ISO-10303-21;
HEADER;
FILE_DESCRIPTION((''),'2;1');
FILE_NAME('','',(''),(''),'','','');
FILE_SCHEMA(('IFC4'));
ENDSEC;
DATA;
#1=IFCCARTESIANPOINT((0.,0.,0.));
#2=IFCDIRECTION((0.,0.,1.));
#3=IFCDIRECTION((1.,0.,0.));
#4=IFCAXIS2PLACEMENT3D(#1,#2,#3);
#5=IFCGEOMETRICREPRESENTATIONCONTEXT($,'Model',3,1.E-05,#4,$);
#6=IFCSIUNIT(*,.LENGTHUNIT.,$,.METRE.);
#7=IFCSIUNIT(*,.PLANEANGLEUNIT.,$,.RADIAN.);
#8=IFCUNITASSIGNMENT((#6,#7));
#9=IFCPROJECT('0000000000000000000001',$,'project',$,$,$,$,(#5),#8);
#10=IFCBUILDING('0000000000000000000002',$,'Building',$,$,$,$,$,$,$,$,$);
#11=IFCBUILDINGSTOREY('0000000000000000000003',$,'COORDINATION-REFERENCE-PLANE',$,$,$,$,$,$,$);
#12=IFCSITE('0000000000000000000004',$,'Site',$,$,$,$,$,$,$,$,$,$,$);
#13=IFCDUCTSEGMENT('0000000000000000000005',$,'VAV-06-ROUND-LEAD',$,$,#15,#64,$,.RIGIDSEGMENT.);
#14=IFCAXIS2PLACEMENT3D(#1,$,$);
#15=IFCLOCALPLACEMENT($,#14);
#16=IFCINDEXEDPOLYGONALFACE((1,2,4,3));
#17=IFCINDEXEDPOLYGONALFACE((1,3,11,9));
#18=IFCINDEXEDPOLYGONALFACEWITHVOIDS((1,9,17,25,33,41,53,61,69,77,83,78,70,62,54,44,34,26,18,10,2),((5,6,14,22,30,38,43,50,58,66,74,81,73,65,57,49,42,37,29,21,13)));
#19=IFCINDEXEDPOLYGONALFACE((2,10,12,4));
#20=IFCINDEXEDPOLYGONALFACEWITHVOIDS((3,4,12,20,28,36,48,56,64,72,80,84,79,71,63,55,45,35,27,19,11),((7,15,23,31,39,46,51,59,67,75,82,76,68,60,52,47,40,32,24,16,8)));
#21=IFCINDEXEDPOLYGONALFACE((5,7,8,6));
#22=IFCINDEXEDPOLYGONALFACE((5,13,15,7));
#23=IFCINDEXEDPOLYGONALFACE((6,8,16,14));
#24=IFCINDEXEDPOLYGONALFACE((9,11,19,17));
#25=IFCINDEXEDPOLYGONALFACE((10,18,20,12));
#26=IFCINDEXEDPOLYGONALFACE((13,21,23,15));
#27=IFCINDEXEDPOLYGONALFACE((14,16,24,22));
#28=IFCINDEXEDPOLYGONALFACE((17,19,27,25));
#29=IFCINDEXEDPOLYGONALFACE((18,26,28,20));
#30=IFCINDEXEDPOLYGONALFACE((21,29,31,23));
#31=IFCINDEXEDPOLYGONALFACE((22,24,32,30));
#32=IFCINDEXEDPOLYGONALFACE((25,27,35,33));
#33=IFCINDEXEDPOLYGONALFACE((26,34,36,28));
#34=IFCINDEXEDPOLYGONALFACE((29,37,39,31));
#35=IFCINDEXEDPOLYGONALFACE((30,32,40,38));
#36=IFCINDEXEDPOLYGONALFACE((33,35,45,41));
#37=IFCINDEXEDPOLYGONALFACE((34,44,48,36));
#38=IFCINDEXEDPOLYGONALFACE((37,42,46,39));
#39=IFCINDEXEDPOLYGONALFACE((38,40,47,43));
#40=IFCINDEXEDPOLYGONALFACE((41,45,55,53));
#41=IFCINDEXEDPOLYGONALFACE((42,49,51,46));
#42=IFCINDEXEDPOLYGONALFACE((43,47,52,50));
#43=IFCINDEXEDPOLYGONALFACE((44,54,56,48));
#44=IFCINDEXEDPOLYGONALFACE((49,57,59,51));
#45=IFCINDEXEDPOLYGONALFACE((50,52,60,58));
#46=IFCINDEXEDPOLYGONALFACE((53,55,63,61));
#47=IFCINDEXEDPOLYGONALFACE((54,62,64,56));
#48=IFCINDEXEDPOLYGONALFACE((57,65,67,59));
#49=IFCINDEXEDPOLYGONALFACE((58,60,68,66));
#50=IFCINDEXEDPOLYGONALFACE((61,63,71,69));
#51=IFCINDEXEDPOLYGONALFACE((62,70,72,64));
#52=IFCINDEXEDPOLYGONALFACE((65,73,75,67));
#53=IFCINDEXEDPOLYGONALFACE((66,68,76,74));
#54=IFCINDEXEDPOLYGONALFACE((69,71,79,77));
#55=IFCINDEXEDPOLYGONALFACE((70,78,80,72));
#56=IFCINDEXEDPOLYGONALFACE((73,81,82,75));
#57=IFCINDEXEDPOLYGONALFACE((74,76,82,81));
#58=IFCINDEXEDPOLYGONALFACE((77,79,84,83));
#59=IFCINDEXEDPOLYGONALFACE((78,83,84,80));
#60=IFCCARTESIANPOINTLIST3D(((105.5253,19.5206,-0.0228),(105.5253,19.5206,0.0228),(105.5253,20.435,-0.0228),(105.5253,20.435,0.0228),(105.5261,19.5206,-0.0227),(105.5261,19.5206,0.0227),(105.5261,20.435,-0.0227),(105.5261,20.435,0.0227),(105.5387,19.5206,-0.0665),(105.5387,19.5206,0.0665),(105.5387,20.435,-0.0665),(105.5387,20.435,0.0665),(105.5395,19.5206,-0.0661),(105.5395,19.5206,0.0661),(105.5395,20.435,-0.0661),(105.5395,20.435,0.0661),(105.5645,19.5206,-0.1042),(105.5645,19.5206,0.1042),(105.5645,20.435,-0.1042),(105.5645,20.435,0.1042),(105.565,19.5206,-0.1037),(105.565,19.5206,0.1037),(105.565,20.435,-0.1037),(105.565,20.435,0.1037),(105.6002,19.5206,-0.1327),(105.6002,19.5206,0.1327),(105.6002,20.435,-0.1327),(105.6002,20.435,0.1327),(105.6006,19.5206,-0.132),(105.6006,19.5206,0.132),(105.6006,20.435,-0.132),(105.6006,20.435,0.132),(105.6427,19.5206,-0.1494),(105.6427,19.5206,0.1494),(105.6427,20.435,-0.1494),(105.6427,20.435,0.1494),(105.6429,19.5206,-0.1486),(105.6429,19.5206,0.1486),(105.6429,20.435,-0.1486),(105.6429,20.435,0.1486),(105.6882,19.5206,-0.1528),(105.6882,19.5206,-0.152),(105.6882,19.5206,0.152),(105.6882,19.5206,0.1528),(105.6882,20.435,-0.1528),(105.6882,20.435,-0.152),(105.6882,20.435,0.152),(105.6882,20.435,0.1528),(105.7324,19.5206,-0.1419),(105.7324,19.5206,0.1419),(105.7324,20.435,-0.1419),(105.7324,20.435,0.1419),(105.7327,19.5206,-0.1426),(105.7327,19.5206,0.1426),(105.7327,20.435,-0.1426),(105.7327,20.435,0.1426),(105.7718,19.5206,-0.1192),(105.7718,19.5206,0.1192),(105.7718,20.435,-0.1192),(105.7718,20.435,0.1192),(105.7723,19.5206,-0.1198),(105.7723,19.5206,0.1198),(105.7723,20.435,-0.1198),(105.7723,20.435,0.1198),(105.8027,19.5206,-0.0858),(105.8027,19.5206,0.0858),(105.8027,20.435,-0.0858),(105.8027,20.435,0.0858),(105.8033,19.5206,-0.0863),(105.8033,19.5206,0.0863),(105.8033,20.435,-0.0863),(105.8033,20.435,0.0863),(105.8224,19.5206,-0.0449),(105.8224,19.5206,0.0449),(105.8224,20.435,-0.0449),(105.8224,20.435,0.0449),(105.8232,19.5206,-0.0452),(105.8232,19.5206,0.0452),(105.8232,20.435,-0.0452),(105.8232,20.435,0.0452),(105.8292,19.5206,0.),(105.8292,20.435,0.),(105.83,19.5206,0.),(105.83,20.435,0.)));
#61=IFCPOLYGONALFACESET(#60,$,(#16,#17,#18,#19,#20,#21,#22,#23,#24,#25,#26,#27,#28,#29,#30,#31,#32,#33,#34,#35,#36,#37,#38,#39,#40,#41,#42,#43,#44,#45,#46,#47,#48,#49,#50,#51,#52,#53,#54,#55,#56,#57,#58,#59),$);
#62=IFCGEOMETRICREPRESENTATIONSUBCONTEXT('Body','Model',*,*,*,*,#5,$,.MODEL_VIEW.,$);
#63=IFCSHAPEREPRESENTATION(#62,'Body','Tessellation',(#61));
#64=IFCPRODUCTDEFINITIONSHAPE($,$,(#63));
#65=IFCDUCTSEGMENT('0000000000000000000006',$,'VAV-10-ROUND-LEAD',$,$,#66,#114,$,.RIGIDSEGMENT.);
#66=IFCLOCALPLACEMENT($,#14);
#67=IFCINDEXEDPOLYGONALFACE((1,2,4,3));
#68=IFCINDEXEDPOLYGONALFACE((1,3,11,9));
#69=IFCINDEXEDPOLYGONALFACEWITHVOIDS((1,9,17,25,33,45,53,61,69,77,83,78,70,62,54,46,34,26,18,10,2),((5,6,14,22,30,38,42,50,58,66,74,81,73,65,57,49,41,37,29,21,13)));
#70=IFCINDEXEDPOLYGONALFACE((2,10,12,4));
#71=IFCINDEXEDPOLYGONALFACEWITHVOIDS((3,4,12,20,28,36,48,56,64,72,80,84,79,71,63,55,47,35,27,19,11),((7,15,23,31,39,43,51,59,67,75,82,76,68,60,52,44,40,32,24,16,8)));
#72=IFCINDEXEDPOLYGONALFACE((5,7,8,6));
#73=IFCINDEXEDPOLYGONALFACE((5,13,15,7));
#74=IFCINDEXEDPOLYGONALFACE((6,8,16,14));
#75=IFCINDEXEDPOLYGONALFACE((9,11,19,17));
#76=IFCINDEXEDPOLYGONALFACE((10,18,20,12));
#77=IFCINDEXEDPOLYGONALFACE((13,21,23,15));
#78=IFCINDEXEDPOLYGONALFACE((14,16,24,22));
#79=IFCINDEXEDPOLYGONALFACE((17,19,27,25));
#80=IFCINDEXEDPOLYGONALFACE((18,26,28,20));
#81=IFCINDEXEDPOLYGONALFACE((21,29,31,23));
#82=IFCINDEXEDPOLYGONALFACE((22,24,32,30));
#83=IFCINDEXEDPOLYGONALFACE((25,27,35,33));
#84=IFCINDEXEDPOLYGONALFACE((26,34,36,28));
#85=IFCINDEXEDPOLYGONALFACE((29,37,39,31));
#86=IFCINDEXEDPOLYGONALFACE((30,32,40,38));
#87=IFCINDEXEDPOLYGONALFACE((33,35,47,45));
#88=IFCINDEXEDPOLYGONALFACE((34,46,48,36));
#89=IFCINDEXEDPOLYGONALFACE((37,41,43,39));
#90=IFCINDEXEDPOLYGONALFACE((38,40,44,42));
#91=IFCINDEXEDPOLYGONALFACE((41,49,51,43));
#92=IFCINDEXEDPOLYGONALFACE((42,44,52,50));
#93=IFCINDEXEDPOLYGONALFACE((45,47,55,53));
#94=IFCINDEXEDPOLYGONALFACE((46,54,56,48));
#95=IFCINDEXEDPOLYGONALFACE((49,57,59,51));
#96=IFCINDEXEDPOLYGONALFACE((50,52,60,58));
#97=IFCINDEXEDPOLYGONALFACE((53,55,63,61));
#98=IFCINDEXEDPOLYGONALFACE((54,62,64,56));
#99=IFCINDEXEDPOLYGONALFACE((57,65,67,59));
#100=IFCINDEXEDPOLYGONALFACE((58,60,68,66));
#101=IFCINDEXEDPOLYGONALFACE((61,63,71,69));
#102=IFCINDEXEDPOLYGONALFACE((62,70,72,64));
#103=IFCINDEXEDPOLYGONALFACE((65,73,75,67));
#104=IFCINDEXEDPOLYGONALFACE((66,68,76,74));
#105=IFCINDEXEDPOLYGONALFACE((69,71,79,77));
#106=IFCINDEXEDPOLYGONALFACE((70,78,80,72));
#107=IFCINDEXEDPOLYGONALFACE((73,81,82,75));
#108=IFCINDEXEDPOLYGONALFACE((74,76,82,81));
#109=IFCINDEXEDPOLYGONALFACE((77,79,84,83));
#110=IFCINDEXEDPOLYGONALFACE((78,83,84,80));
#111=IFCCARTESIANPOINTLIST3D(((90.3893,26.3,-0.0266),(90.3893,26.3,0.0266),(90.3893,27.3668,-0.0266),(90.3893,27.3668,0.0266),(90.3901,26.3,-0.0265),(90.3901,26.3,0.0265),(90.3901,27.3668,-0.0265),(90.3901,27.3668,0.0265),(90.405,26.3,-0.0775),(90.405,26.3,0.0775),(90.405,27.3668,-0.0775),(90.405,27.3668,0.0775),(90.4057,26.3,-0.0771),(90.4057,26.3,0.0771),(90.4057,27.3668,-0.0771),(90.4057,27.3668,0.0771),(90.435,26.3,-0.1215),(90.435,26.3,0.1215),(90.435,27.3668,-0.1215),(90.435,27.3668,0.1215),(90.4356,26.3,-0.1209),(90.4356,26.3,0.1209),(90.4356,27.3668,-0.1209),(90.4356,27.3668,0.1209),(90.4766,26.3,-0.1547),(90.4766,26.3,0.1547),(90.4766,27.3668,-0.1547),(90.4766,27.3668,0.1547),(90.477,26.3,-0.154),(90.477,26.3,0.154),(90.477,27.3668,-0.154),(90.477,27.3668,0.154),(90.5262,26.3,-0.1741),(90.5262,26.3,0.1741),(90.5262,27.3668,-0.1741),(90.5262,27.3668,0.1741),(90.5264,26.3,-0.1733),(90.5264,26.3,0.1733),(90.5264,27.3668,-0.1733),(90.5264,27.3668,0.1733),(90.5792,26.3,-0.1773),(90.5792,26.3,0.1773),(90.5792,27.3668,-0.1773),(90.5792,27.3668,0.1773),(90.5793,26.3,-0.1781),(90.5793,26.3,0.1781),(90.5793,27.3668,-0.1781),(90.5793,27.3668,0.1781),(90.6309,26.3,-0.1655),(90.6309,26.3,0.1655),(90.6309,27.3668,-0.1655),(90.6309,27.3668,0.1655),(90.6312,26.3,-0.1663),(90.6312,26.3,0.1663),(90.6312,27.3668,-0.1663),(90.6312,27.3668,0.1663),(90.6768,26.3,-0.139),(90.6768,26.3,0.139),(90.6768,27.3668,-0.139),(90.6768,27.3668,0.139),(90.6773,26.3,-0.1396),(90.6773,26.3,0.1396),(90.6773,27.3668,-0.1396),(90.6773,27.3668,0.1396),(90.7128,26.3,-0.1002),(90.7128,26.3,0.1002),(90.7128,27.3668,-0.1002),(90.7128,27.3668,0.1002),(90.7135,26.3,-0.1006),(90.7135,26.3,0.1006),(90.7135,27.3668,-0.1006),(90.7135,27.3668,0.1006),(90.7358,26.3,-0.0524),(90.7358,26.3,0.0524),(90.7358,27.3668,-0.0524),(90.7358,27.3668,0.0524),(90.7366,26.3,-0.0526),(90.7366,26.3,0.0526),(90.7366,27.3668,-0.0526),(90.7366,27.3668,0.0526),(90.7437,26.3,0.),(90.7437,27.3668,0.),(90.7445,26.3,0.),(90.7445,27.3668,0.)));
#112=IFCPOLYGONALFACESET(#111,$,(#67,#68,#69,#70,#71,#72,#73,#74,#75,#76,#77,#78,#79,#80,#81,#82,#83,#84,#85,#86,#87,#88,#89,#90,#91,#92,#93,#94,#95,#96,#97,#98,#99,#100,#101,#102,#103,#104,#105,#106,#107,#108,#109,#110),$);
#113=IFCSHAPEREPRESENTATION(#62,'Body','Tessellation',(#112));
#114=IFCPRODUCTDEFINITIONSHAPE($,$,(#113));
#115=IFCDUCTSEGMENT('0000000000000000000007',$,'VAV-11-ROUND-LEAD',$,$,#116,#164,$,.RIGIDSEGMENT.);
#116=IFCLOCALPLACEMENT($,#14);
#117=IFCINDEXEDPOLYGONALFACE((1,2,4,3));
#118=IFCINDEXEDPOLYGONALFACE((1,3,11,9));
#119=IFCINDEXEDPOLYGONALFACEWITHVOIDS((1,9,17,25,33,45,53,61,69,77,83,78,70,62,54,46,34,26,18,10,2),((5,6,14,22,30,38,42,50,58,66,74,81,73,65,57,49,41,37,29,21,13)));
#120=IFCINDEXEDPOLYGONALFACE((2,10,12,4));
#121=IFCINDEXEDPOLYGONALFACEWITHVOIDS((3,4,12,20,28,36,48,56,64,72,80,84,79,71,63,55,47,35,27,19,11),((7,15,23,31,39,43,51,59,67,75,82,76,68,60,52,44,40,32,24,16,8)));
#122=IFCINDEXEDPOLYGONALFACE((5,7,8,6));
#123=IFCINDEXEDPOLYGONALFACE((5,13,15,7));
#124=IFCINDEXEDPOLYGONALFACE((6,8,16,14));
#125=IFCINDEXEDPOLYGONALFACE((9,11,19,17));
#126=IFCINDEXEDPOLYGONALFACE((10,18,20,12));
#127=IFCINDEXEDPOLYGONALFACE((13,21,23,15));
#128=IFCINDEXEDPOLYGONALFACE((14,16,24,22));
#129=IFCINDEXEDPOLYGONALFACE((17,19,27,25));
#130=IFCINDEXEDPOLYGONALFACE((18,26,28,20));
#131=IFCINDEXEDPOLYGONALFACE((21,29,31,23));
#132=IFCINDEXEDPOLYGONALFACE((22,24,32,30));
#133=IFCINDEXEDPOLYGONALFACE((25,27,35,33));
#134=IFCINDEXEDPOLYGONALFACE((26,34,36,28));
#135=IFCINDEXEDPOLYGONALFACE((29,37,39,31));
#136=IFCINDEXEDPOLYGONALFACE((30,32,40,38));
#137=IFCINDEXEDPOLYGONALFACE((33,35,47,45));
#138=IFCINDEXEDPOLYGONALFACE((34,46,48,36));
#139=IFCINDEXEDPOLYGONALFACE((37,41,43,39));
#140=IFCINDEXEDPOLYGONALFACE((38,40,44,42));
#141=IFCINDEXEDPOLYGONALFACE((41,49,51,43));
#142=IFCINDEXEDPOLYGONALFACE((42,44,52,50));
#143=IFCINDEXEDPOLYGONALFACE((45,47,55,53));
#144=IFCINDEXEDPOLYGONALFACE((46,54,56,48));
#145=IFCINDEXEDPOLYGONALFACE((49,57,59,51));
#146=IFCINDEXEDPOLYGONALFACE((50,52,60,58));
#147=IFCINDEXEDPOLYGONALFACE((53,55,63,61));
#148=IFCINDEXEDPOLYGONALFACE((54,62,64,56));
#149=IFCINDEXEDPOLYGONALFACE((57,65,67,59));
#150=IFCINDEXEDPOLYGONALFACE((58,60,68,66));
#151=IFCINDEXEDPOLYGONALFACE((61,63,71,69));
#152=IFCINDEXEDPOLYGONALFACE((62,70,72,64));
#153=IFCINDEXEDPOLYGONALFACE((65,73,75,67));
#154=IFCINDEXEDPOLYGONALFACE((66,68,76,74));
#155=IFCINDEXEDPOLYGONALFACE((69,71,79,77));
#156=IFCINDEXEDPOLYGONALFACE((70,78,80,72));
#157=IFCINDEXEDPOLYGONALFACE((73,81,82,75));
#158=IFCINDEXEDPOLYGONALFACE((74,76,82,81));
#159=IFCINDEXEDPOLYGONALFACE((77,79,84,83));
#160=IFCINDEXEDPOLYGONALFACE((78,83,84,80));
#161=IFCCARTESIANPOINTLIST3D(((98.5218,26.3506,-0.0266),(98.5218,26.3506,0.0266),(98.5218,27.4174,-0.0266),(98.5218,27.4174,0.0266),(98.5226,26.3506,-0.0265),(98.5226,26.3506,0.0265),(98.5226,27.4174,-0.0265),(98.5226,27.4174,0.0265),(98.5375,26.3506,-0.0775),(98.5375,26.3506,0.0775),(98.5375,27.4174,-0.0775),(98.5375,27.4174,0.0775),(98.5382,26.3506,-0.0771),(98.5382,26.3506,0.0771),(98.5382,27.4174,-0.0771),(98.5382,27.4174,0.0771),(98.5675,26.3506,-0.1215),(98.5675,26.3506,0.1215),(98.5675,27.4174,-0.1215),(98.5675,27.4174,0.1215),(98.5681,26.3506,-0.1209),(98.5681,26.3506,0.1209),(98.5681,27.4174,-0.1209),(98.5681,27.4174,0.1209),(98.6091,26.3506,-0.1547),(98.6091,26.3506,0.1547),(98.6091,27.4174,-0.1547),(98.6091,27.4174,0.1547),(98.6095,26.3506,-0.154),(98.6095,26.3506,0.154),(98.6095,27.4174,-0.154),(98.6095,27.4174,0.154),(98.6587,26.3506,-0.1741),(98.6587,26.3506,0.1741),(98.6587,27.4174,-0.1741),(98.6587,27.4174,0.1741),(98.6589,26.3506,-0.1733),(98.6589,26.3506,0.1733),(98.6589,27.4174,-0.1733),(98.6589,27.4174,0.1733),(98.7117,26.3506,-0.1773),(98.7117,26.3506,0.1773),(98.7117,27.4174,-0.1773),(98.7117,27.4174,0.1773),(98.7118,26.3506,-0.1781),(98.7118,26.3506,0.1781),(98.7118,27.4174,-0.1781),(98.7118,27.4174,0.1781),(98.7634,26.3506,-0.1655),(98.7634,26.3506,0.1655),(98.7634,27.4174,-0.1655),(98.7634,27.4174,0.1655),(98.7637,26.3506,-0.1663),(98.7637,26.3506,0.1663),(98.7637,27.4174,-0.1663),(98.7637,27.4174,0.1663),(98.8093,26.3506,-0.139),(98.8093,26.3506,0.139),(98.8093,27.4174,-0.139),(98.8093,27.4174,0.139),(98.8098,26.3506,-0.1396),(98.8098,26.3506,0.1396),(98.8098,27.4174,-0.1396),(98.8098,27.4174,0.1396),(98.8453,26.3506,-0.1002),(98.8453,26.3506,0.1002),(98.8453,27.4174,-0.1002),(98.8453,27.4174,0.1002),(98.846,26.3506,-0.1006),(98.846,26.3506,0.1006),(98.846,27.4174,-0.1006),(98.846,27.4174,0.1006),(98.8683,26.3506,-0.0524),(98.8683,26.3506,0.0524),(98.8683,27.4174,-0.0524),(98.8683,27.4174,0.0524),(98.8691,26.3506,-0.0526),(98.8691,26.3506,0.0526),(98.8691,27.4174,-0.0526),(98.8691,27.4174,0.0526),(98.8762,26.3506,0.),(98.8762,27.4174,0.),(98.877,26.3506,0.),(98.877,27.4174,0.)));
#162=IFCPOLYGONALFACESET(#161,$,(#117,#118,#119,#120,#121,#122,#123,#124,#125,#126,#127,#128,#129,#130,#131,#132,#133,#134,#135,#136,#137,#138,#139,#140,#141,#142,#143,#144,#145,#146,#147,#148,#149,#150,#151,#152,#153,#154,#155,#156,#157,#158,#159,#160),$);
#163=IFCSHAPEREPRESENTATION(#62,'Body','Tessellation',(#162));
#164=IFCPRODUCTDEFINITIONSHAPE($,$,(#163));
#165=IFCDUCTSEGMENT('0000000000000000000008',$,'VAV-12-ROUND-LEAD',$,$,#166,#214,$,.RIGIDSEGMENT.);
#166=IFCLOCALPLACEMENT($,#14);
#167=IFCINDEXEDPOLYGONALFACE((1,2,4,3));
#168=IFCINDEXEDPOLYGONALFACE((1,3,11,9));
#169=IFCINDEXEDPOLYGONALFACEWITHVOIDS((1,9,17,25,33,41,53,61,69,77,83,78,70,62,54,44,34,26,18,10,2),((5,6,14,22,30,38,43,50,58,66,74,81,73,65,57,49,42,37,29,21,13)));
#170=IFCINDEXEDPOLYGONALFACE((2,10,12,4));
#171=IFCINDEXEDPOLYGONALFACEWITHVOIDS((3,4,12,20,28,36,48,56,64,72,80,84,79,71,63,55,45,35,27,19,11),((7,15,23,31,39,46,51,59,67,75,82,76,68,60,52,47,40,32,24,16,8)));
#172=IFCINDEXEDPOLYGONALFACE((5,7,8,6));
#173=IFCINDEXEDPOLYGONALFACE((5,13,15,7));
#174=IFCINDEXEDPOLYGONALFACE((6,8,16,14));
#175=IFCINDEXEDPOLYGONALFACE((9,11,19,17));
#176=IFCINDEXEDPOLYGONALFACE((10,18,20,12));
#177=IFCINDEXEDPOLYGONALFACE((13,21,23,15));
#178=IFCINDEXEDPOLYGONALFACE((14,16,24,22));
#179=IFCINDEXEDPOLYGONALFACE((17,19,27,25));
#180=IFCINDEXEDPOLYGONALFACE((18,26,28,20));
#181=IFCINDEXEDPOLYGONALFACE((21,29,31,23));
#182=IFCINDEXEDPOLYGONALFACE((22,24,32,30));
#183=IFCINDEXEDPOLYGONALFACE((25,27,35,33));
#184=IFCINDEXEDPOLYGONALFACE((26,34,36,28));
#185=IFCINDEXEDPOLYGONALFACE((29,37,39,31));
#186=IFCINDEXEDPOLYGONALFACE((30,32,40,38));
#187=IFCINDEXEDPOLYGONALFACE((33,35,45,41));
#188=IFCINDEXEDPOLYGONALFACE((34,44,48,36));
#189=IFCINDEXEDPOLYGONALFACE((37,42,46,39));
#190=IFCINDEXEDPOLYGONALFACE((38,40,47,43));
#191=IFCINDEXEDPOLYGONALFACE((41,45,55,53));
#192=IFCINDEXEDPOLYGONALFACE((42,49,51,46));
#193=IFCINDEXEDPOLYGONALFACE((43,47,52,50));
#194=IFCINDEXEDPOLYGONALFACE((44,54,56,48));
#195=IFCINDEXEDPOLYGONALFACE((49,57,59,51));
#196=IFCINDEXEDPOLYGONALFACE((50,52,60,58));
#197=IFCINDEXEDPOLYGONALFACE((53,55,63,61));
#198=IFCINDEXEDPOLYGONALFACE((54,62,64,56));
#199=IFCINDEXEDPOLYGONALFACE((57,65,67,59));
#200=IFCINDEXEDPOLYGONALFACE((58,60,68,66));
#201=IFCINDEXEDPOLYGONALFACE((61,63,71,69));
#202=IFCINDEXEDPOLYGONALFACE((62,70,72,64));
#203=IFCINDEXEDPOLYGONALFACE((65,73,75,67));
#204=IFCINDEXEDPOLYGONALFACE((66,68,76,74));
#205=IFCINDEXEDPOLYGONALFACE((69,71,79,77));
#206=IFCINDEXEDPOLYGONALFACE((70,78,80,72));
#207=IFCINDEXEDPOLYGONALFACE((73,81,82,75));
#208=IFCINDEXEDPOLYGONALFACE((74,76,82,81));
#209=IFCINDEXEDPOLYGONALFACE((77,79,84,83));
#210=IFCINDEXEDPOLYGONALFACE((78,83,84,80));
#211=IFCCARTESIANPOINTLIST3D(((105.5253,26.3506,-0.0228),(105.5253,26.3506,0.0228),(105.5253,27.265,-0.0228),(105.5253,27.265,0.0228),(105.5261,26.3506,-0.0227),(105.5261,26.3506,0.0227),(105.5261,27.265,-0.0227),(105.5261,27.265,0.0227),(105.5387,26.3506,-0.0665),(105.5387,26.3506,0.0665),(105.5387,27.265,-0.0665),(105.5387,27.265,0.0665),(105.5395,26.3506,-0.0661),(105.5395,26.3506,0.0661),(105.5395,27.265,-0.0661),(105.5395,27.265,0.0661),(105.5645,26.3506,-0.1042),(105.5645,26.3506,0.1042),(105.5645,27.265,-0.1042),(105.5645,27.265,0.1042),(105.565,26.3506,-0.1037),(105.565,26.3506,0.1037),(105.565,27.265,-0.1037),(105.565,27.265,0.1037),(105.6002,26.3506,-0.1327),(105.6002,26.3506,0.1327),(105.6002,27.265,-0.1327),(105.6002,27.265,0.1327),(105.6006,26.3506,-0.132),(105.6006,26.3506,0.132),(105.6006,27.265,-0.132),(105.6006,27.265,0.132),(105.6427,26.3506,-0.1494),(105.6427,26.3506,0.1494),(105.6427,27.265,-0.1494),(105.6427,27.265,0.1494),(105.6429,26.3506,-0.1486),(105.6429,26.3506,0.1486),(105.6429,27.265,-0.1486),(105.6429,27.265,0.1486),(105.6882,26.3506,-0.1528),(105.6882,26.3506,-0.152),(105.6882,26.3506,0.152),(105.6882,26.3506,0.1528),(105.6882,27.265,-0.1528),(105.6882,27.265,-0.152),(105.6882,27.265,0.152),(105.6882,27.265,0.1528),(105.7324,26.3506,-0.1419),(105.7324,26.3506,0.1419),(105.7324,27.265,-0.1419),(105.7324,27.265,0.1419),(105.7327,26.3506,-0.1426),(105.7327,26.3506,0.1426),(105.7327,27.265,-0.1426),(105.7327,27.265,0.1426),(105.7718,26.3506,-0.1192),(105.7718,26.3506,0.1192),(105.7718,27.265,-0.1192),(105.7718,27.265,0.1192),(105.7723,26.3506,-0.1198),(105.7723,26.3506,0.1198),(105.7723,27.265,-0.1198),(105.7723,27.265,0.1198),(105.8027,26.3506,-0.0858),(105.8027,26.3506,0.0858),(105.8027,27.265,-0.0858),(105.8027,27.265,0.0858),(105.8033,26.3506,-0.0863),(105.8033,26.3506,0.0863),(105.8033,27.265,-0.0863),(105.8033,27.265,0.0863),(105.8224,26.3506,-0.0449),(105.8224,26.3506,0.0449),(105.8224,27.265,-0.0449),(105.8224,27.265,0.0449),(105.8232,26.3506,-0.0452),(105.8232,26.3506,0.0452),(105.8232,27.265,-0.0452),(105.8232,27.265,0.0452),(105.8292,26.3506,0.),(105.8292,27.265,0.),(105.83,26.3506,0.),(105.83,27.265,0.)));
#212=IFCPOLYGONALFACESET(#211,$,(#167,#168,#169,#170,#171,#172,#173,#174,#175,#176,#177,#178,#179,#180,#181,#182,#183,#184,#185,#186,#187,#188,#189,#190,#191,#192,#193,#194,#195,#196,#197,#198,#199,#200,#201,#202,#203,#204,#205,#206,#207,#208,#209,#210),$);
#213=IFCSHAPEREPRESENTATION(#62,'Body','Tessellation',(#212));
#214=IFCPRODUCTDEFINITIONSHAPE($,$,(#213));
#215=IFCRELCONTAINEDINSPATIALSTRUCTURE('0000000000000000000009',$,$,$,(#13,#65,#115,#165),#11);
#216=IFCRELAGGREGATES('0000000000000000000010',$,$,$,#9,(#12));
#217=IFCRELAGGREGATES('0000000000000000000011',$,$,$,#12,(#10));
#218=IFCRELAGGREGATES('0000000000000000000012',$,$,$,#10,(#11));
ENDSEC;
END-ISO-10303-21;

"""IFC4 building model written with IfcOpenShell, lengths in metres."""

from ifc_helpers import new_model, si_unit, frame, origin, origin_with_axes, place, context, subcontext, project, spatial, hollow_circle, extrude, element, save


model = new_model("IFC4")

# Units and contexts
model_context = context("Model", 3, precision=1e-05, world=origin_with_axes())
body_context_1 = subcontext(model_context, "Body", "Model", "MODEL_VIEW")
ifc_project = project(units=[si_unit("LENGTHUNIT", "METRE"), si_unit("PLANEANGLEUNIT", "RADIAN")], contexts=[model_context])

# Site, building, storey
site = spatial("IfcSite", under=ifc_project, Name="Site")
building = spatial("IfcBuilding", under=site, Name="Building")
storey = spatial("IfcBuildingStorey", under=building, Name="COORDINATION-REFERENCE-PLANE")

# Duct segments
duct_segment_1_placement = place(None, frame((105.6768, 20.435, 0.0), z_axis=(0.0, -1.0, 0.0), x_axis=(1.0, 0.0, 0.0)))
element("IfcDuctSegment", 1, at=duct_segment_1_placement, inside=storey, Name="VAV-06-ROUND-LEAD", PredefinedType="RIGIDSEGMENT", context=body_context_1, shape_type="SweptSolid", body=[
    extrude(hollow_circle(Radius=0.1532, WallThickness=0.0008), origin(), (0.0, 0.0, 1.0), 0.9144),
])
for number, where, z_axis, x_axis, name in (
    (2, (90.5659, 27.3668, 0.0), (0.0, -1.0, 0.0), (1.0, 0.0, 0.0), "VAV-10-ROUND-LEAD"),
    (3, (98.6984, 27.4174, 0.0), (0.0, -1.0, 0.0), (1.0, 0.0, 0.0), "VAV-11-ROUND-LEAD"),
):
    element("IfcDuctSegment", number, at=place(None, frame(where, z_axis=z_axis, x_axis=x_axis)), inside=storey, Name=name, PredefinedType="RIGIDSEGMENT", context=body_context_1, shape_type="SweptSolid", body=[
        extrude(hollow_circle(Radius=0.1786, WallThickness=0.0008), origin(), (0.0, 0.0, 1.0), 1.0668),
    ])
duct_segment_2_placement = place(None, frame((105.6768, 27.265, 0.0), z_axis=(0.0, -1.0, 0.0), x_axis=(1.0, 0.0, 0.0)))
element("IfcDuctSegment", 4, at=duct_segment_2_placement, inside=storey, Name="VAV-12-ROUND-LEAD", PredefinedType="RIGIDSEGMENT", context=body_context_1, shape_type="SweptSolid", body=[
    extrude(hollow_circle(Radius=0.1532, WallThickness=0.0008), origin(), (0.0, 0.0, 1.0), 0.9144),
])

save(model, "model.ifc")
